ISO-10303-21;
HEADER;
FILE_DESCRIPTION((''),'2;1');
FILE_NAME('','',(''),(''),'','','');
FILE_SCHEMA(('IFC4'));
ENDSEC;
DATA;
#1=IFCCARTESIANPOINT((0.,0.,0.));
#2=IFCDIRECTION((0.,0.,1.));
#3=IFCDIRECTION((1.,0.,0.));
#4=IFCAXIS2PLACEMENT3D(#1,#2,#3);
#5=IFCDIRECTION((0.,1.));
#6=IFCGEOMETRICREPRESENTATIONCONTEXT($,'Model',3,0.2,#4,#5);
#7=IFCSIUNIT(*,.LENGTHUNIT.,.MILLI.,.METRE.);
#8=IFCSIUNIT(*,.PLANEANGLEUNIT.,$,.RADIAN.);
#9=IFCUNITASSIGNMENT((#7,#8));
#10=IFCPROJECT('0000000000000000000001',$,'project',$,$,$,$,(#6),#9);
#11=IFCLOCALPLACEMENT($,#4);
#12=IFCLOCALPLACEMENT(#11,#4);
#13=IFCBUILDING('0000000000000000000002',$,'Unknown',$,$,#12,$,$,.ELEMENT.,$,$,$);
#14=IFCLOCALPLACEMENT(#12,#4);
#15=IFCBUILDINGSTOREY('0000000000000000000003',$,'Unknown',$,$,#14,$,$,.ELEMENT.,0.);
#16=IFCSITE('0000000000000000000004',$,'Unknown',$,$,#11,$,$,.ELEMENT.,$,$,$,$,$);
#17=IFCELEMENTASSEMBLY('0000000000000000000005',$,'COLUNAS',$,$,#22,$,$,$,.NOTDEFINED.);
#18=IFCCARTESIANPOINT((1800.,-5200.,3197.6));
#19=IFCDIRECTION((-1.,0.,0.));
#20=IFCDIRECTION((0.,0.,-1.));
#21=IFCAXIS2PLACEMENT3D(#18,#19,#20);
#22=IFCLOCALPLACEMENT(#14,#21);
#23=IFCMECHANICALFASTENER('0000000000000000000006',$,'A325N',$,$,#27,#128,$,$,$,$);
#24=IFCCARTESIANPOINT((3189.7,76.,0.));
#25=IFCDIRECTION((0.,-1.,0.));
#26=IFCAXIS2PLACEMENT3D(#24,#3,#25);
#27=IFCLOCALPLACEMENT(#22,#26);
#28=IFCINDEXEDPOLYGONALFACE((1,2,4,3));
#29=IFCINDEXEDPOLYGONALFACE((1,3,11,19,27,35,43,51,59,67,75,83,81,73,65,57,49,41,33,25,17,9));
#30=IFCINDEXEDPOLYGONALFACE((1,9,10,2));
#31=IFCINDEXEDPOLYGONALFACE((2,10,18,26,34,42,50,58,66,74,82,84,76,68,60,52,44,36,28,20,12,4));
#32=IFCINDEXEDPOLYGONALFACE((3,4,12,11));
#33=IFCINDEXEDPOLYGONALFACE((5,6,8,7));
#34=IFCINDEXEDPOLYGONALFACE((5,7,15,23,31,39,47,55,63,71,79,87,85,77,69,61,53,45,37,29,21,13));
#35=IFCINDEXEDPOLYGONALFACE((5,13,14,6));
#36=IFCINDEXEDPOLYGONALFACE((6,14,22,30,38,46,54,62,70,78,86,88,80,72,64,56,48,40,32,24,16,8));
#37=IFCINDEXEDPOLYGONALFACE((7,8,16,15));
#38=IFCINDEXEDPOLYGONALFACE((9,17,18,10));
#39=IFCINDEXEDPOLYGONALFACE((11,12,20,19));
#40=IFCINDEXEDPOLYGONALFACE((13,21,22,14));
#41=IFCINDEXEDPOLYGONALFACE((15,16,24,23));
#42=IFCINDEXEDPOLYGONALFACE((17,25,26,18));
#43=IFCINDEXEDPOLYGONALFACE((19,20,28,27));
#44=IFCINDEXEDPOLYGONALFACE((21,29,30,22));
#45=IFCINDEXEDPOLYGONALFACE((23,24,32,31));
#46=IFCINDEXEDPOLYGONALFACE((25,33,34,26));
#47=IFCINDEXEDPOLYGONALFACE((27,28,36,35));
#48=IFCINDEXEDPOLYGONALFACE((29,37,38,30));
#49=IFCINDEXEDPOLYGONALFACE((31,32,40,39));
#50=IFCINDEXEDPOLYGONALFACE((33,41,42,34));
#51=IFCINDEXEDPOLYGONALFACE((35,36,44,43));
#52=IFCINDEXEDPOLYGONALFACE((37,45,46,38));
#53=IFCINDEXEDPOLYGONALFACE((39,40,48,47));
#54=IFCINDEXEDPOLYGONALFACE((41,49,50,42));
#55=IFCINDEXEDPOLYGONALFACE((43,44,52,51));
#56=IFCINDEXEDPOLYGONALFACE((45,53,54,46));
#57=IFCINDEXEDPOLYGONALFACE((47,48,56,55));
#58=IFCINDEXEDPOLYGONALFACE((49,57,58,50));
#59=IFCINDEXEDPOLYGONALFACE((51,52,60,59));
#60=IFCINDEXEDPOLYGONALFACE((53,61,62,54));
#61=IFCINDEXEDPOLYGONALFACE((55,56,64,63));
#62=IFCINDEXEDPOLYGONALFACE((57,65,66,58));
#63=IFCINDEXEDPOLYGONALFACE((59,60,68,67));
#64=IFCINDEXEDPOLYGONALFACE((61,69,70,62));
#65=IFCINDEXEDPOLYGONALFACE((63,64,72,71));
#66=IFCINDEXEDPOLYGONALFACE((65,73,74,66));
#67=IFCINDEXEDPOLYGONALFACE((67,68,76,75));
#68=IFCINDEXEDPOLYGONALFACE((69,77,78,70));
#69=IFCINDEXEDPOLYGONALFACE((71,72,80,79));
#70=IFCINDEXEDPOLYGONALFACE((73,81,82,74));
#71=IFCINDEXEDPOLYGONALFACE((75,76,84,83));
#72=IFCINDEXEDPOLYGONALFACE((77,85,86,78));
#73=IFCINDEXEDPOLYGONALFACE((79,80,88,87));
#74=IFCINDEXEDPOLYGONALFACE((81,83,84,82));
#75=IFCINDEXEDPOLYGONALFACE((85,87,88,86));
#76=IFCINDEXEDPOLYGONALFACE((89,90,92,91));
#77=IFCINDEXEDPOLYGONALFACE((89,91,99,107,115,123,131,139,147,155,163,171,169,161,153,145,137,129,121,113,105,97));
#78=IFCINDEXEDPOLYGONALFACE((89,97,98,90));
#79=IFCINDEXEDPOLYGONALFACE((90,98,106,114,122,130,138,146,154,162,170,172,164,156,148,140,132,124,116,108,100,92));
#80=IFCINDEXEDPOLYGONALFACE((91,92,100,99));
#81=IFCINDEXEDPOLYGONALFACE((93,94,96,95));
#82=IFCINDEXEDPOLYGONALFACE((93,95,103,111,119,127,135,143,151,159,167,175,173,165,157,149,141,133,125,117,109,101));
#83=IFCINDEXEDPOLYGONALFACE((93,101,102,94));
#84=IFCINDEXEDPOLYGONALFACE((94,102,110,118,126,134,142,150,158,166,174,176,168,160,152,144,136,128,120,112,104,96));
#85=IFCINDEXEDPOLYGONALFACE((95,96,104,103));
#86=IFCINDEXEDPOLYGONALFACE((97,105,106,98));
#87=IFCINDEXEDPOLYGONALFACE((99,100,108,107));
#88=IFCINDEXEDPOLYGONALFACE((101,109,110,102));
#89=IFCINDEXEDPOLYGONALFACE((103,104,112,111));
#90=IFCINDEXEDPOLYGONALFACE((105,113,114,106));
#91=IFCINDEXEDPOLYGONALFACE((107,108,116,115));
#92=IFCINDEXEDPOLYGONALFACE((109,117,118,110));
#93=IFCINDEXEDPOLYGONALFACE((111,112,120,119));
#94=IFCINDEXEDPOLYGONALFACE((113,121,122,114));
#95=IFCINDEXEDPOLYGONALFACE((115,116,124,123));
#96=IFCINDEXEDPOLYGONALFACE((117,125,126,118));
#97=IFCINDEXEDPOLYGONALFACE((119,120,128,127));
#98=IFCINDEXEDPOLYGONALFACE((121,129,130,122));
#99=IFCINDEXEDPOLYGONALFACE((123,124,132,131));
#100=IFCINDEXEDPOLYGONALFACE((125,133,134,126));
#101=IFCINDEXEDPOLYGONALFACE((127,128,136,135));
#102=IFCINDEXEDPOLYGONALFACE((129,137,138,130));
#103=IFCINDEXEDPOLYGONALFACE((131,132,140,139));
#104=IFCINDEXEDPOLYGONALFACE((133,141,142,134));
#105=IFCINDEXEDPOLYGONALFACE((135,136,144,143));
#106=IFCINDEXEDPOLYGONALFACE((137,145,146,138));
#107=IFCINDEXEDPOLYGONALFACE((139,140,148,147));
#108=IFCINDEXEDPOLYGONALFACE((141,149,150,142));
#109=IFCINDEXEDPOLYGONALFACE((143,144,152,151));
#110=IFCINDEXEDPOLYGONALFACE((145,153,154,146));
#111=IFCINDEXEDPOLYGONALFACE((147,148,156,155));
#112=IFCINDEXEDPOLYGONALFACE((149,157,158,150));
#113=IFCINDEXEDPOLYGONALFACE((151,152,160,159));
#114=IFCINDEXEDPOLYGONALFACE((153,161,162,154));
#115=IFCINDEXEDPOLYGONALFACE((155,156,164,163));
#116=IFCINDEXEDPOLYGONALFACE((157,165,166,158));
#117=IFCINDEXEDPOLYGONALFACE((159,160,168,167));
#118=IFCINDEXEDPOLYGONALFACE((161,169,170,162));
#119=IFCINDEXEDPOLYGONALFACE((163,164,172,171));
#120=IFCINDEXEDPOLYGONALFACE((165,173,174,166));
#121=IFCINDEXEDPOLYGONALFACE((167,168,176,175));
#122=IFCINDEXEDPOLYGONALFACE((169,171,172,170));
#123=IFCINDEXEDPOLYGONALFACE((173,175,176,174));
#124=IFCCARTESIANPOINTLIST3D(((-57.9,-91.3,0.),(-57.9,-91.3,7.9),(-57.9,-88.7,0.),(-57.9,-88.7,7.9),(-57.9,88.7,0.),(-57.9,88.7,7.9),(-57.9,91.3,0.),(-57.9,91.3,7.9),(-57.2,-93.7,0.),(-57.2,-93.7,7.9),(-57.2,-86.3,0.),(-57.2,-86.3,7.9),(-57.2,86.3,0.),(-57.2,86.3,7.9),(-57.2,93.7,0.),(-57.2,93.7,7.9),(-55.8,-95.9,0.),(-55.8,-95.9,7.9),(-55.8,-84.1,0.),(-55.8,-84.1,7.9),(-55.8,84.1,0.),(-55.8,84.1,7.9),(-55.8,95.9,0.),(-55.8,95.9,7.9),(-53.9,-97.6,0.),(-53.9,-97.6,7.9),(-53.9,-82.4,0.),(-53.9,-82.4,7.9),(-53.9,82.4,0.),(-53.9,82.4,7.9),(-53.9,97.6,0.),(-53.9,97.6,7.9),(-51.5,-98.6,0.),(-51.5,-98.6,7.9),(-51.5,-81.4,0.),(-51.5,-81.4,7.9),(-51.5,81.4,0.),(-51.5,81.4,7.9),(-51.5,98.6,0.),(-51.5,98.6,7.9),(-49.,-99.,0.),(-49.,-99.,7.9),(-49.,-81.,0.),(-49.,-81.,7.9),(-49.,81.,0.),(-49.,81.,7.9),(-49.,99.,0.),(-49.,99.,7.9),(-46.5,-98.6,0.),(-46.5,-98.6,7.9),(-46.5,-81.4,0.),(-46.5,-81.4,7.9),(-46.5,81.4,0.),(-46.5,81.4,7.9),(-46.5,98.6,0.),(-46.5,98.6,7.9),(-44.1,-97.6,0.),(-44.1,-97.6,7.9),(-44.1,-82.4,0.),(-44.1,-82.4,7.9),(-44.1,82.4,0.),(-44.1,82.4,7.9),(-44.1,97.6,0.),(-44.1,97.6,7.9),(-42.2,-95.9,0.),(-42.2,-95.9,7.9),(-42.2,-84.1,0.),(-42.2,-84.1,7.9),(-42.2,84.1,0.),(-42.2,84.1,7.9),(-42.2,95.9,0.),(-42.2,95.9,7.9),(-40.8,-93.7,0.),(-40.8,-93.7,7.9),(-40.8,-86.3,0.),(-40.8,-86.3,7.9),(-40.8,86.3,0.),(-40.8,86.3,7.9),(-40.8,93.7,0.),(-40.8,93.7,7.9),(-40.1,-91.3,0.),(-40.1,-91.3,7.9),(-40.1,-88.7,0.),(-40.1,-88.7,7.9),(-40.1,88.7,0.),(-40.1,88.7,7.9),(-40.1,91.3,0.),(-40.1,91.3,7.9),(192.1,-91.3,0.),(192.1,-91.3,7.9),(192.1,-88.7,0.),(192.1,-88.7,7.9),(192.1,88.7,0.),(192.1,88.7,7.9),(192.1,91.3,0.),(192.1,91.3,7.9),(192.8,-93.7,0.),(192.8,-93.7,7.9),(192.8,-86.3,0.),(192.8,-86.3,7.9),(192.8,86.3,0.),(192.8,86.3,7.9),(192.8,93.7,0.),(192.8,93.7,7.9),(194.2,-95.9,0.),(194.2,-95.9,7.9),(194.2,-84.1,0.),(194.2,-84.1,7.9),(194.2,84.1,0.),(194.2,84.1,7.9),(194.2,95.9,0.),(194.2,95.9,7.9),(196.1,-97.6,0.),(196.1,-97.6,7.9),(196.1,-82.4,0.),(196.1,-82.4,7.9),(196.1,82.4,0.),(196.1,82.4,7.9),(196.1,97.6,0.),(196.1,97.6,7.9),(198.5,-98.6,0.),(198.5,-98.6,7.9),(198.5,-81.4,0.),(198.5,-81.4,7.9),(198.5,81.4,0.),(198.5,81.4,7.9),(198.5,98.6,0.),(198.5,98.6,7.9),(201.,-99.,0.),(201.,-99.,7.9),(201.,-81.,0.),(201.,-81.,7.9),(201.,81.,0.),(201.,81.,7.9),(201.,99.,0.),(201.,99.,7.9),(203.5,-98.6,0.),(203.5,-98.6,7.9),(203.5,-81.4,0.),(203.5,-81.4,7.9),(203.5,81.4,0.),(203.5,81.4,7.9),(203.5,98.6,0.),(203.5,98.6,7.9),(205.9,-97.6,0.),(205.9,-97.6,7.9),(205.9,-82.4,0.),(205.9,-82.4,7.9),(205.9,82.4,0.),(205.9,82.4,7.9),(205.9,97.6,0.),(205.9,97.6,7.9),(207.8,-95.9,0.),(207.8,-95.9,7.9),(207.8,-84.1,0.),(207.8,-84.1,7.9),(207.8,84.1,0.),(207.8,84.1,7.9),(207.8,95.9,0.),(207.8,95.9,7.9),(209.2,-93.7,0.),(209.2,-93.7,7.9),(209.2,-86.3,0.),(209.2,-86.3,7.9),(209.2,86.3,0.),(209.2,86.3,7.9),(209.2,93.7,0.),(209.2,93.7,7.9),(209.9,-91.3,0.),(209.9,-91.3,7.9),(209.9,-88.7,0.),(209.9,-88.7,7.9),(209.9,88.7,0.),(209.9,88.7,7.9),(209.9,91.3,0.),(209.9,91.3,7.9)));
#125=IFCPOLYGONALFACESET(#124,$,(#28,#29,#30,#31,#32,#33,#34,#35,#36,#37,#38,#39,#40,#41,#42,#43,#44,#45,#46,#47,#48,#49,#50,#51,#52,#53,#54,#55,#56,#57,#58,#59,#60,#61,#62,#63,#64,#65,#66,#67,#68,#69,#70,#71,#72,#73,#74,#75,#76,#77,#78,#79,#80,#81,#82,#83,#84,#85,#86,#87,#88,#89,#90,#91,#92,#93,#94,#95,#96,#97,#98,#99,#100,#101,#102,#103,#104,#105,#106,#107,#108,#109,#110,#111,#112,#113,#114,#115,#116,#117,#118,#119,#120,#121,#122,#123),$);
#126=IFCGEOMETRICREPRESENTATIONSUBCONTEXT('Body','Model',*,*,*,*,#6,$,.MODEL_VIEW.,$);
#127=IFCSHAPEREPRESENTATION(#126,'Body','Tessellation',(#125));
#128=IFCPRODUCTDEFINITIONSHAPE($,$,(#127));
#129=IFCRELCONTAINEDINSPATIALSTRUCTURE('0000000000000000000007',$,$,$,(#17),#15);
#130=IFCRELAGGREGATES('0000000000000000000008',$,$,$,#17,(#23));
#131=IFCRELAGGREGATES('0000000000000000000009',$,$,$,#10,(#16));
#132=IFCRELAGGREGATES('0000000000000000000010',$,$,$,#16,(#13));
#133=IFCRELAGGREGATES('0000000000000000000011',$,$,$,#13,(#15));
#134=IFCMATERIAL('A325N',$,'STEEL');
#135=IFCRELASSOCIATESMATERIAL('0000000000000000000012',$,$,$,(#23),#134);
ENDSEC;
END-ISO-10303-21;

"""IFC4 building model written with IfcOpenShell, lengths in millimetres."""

from ifc_helpers import new_model, si_unit, direction, frame, origin_with_axes, place, context, subcontext, project, spatial, arc, indexed_curve, outline, extrude, source, transform, mapped, material, element, aggregate, save


model = new_model("IFC4")

# Units and contexts
model_context = context("Model", 3, precision=0.2, world=origin_with_axes(), true_north=direction((0.0, 1.0)))
body_context = subcontext(model_context, "Body", "Model", "MODEL_VIEW")
ifc_project = project(units=[si_unit("LENGTHUNIT", "METRE", prefix="MILLI"), si_unit("PLANEANGLEUNIT", "RADIAN")], contexts=[model_context])

# Site, building, storey
site_placement = place(None, origin_with_axes())
site = spatial("IfcSite", under=ifc_project, at=site_placement, Name="Unknown", CompositionType="ELEMENT")
building_placement = place(site_placement, origin_with_axes())
building = spatial("IfcBuilding", under=site, at=building_placement, Name="Unknown", CompositionType="ELEMENT")
storey_placement = place(building_placement, origin_with_axes())
storey = spatial("IfcBuildingStorey", under=building, at=storey_placement, Name="Unknown", CompositionType="ELEMENT", Elevation=0.0)

# Element assembly
assembly_1_placement = place(storey_placement, frame((1800.0, -5200.0, 3197.6), z_axis=(-1.0, 0.0, 0.0), x_axis=(0.0, 0.0, -1.0)))
assembly_1 = element("IfcElementAssembly", 1, at=assembly_1_placement, inside=storey, Name="COLUNAS", PredefinedType="NOTDEFINED")

# Mechanical fastener
ifc_material_1 = material(Name="A325N", Category="STEEL")
shared_shape = source(origin_with_axes(), body_context, "Body", "SweptSolid", [
    extrude(outline(indexed_curve([(9.0, 0.0), (0.0, 9.0), (-9.0, 0.0), (0.0, -9.0)], segments=[arc(1, 2, 3), arc(3, 4, 1)])), frame((0.0, 0.0, 7.9), z_axis=(0.0, 0.0, -1.0), x_axis=(0.0, 1.0, 0.0)), (0.0, 0.0, 1.0), 7.9),
])
mechanical_fastener_1_placement = place(assembly_1_placement, frame((3189.7, 76.0, 0.0), z_axis=(1.0, 0.0, 0.0), x_axis=(0.0, -1.0, 0.0)))
mechanical_fastener_1 = element("IfcMechanicalFastener", 2, at=mechanical_fastener_1_placement, material=ifc_material_1, Name="A325N", context=body_context, shape_type="MappedRepresentation", body=[
    mapped(shared_shape, transform((-49.0, -90.0, 0.0))),
    mapped(shared_shape, transform((-49.0, 90.0, 0.0))),
    mapped(shared_shape, transform((201.0, -90.0, 0.0))),
    mapped(shared_shape, transform((201.0, 90.0, 0.0))),
])
aggregate(assembly_1, [mechanical_fastener_1])

save(model, "model.ifc")
